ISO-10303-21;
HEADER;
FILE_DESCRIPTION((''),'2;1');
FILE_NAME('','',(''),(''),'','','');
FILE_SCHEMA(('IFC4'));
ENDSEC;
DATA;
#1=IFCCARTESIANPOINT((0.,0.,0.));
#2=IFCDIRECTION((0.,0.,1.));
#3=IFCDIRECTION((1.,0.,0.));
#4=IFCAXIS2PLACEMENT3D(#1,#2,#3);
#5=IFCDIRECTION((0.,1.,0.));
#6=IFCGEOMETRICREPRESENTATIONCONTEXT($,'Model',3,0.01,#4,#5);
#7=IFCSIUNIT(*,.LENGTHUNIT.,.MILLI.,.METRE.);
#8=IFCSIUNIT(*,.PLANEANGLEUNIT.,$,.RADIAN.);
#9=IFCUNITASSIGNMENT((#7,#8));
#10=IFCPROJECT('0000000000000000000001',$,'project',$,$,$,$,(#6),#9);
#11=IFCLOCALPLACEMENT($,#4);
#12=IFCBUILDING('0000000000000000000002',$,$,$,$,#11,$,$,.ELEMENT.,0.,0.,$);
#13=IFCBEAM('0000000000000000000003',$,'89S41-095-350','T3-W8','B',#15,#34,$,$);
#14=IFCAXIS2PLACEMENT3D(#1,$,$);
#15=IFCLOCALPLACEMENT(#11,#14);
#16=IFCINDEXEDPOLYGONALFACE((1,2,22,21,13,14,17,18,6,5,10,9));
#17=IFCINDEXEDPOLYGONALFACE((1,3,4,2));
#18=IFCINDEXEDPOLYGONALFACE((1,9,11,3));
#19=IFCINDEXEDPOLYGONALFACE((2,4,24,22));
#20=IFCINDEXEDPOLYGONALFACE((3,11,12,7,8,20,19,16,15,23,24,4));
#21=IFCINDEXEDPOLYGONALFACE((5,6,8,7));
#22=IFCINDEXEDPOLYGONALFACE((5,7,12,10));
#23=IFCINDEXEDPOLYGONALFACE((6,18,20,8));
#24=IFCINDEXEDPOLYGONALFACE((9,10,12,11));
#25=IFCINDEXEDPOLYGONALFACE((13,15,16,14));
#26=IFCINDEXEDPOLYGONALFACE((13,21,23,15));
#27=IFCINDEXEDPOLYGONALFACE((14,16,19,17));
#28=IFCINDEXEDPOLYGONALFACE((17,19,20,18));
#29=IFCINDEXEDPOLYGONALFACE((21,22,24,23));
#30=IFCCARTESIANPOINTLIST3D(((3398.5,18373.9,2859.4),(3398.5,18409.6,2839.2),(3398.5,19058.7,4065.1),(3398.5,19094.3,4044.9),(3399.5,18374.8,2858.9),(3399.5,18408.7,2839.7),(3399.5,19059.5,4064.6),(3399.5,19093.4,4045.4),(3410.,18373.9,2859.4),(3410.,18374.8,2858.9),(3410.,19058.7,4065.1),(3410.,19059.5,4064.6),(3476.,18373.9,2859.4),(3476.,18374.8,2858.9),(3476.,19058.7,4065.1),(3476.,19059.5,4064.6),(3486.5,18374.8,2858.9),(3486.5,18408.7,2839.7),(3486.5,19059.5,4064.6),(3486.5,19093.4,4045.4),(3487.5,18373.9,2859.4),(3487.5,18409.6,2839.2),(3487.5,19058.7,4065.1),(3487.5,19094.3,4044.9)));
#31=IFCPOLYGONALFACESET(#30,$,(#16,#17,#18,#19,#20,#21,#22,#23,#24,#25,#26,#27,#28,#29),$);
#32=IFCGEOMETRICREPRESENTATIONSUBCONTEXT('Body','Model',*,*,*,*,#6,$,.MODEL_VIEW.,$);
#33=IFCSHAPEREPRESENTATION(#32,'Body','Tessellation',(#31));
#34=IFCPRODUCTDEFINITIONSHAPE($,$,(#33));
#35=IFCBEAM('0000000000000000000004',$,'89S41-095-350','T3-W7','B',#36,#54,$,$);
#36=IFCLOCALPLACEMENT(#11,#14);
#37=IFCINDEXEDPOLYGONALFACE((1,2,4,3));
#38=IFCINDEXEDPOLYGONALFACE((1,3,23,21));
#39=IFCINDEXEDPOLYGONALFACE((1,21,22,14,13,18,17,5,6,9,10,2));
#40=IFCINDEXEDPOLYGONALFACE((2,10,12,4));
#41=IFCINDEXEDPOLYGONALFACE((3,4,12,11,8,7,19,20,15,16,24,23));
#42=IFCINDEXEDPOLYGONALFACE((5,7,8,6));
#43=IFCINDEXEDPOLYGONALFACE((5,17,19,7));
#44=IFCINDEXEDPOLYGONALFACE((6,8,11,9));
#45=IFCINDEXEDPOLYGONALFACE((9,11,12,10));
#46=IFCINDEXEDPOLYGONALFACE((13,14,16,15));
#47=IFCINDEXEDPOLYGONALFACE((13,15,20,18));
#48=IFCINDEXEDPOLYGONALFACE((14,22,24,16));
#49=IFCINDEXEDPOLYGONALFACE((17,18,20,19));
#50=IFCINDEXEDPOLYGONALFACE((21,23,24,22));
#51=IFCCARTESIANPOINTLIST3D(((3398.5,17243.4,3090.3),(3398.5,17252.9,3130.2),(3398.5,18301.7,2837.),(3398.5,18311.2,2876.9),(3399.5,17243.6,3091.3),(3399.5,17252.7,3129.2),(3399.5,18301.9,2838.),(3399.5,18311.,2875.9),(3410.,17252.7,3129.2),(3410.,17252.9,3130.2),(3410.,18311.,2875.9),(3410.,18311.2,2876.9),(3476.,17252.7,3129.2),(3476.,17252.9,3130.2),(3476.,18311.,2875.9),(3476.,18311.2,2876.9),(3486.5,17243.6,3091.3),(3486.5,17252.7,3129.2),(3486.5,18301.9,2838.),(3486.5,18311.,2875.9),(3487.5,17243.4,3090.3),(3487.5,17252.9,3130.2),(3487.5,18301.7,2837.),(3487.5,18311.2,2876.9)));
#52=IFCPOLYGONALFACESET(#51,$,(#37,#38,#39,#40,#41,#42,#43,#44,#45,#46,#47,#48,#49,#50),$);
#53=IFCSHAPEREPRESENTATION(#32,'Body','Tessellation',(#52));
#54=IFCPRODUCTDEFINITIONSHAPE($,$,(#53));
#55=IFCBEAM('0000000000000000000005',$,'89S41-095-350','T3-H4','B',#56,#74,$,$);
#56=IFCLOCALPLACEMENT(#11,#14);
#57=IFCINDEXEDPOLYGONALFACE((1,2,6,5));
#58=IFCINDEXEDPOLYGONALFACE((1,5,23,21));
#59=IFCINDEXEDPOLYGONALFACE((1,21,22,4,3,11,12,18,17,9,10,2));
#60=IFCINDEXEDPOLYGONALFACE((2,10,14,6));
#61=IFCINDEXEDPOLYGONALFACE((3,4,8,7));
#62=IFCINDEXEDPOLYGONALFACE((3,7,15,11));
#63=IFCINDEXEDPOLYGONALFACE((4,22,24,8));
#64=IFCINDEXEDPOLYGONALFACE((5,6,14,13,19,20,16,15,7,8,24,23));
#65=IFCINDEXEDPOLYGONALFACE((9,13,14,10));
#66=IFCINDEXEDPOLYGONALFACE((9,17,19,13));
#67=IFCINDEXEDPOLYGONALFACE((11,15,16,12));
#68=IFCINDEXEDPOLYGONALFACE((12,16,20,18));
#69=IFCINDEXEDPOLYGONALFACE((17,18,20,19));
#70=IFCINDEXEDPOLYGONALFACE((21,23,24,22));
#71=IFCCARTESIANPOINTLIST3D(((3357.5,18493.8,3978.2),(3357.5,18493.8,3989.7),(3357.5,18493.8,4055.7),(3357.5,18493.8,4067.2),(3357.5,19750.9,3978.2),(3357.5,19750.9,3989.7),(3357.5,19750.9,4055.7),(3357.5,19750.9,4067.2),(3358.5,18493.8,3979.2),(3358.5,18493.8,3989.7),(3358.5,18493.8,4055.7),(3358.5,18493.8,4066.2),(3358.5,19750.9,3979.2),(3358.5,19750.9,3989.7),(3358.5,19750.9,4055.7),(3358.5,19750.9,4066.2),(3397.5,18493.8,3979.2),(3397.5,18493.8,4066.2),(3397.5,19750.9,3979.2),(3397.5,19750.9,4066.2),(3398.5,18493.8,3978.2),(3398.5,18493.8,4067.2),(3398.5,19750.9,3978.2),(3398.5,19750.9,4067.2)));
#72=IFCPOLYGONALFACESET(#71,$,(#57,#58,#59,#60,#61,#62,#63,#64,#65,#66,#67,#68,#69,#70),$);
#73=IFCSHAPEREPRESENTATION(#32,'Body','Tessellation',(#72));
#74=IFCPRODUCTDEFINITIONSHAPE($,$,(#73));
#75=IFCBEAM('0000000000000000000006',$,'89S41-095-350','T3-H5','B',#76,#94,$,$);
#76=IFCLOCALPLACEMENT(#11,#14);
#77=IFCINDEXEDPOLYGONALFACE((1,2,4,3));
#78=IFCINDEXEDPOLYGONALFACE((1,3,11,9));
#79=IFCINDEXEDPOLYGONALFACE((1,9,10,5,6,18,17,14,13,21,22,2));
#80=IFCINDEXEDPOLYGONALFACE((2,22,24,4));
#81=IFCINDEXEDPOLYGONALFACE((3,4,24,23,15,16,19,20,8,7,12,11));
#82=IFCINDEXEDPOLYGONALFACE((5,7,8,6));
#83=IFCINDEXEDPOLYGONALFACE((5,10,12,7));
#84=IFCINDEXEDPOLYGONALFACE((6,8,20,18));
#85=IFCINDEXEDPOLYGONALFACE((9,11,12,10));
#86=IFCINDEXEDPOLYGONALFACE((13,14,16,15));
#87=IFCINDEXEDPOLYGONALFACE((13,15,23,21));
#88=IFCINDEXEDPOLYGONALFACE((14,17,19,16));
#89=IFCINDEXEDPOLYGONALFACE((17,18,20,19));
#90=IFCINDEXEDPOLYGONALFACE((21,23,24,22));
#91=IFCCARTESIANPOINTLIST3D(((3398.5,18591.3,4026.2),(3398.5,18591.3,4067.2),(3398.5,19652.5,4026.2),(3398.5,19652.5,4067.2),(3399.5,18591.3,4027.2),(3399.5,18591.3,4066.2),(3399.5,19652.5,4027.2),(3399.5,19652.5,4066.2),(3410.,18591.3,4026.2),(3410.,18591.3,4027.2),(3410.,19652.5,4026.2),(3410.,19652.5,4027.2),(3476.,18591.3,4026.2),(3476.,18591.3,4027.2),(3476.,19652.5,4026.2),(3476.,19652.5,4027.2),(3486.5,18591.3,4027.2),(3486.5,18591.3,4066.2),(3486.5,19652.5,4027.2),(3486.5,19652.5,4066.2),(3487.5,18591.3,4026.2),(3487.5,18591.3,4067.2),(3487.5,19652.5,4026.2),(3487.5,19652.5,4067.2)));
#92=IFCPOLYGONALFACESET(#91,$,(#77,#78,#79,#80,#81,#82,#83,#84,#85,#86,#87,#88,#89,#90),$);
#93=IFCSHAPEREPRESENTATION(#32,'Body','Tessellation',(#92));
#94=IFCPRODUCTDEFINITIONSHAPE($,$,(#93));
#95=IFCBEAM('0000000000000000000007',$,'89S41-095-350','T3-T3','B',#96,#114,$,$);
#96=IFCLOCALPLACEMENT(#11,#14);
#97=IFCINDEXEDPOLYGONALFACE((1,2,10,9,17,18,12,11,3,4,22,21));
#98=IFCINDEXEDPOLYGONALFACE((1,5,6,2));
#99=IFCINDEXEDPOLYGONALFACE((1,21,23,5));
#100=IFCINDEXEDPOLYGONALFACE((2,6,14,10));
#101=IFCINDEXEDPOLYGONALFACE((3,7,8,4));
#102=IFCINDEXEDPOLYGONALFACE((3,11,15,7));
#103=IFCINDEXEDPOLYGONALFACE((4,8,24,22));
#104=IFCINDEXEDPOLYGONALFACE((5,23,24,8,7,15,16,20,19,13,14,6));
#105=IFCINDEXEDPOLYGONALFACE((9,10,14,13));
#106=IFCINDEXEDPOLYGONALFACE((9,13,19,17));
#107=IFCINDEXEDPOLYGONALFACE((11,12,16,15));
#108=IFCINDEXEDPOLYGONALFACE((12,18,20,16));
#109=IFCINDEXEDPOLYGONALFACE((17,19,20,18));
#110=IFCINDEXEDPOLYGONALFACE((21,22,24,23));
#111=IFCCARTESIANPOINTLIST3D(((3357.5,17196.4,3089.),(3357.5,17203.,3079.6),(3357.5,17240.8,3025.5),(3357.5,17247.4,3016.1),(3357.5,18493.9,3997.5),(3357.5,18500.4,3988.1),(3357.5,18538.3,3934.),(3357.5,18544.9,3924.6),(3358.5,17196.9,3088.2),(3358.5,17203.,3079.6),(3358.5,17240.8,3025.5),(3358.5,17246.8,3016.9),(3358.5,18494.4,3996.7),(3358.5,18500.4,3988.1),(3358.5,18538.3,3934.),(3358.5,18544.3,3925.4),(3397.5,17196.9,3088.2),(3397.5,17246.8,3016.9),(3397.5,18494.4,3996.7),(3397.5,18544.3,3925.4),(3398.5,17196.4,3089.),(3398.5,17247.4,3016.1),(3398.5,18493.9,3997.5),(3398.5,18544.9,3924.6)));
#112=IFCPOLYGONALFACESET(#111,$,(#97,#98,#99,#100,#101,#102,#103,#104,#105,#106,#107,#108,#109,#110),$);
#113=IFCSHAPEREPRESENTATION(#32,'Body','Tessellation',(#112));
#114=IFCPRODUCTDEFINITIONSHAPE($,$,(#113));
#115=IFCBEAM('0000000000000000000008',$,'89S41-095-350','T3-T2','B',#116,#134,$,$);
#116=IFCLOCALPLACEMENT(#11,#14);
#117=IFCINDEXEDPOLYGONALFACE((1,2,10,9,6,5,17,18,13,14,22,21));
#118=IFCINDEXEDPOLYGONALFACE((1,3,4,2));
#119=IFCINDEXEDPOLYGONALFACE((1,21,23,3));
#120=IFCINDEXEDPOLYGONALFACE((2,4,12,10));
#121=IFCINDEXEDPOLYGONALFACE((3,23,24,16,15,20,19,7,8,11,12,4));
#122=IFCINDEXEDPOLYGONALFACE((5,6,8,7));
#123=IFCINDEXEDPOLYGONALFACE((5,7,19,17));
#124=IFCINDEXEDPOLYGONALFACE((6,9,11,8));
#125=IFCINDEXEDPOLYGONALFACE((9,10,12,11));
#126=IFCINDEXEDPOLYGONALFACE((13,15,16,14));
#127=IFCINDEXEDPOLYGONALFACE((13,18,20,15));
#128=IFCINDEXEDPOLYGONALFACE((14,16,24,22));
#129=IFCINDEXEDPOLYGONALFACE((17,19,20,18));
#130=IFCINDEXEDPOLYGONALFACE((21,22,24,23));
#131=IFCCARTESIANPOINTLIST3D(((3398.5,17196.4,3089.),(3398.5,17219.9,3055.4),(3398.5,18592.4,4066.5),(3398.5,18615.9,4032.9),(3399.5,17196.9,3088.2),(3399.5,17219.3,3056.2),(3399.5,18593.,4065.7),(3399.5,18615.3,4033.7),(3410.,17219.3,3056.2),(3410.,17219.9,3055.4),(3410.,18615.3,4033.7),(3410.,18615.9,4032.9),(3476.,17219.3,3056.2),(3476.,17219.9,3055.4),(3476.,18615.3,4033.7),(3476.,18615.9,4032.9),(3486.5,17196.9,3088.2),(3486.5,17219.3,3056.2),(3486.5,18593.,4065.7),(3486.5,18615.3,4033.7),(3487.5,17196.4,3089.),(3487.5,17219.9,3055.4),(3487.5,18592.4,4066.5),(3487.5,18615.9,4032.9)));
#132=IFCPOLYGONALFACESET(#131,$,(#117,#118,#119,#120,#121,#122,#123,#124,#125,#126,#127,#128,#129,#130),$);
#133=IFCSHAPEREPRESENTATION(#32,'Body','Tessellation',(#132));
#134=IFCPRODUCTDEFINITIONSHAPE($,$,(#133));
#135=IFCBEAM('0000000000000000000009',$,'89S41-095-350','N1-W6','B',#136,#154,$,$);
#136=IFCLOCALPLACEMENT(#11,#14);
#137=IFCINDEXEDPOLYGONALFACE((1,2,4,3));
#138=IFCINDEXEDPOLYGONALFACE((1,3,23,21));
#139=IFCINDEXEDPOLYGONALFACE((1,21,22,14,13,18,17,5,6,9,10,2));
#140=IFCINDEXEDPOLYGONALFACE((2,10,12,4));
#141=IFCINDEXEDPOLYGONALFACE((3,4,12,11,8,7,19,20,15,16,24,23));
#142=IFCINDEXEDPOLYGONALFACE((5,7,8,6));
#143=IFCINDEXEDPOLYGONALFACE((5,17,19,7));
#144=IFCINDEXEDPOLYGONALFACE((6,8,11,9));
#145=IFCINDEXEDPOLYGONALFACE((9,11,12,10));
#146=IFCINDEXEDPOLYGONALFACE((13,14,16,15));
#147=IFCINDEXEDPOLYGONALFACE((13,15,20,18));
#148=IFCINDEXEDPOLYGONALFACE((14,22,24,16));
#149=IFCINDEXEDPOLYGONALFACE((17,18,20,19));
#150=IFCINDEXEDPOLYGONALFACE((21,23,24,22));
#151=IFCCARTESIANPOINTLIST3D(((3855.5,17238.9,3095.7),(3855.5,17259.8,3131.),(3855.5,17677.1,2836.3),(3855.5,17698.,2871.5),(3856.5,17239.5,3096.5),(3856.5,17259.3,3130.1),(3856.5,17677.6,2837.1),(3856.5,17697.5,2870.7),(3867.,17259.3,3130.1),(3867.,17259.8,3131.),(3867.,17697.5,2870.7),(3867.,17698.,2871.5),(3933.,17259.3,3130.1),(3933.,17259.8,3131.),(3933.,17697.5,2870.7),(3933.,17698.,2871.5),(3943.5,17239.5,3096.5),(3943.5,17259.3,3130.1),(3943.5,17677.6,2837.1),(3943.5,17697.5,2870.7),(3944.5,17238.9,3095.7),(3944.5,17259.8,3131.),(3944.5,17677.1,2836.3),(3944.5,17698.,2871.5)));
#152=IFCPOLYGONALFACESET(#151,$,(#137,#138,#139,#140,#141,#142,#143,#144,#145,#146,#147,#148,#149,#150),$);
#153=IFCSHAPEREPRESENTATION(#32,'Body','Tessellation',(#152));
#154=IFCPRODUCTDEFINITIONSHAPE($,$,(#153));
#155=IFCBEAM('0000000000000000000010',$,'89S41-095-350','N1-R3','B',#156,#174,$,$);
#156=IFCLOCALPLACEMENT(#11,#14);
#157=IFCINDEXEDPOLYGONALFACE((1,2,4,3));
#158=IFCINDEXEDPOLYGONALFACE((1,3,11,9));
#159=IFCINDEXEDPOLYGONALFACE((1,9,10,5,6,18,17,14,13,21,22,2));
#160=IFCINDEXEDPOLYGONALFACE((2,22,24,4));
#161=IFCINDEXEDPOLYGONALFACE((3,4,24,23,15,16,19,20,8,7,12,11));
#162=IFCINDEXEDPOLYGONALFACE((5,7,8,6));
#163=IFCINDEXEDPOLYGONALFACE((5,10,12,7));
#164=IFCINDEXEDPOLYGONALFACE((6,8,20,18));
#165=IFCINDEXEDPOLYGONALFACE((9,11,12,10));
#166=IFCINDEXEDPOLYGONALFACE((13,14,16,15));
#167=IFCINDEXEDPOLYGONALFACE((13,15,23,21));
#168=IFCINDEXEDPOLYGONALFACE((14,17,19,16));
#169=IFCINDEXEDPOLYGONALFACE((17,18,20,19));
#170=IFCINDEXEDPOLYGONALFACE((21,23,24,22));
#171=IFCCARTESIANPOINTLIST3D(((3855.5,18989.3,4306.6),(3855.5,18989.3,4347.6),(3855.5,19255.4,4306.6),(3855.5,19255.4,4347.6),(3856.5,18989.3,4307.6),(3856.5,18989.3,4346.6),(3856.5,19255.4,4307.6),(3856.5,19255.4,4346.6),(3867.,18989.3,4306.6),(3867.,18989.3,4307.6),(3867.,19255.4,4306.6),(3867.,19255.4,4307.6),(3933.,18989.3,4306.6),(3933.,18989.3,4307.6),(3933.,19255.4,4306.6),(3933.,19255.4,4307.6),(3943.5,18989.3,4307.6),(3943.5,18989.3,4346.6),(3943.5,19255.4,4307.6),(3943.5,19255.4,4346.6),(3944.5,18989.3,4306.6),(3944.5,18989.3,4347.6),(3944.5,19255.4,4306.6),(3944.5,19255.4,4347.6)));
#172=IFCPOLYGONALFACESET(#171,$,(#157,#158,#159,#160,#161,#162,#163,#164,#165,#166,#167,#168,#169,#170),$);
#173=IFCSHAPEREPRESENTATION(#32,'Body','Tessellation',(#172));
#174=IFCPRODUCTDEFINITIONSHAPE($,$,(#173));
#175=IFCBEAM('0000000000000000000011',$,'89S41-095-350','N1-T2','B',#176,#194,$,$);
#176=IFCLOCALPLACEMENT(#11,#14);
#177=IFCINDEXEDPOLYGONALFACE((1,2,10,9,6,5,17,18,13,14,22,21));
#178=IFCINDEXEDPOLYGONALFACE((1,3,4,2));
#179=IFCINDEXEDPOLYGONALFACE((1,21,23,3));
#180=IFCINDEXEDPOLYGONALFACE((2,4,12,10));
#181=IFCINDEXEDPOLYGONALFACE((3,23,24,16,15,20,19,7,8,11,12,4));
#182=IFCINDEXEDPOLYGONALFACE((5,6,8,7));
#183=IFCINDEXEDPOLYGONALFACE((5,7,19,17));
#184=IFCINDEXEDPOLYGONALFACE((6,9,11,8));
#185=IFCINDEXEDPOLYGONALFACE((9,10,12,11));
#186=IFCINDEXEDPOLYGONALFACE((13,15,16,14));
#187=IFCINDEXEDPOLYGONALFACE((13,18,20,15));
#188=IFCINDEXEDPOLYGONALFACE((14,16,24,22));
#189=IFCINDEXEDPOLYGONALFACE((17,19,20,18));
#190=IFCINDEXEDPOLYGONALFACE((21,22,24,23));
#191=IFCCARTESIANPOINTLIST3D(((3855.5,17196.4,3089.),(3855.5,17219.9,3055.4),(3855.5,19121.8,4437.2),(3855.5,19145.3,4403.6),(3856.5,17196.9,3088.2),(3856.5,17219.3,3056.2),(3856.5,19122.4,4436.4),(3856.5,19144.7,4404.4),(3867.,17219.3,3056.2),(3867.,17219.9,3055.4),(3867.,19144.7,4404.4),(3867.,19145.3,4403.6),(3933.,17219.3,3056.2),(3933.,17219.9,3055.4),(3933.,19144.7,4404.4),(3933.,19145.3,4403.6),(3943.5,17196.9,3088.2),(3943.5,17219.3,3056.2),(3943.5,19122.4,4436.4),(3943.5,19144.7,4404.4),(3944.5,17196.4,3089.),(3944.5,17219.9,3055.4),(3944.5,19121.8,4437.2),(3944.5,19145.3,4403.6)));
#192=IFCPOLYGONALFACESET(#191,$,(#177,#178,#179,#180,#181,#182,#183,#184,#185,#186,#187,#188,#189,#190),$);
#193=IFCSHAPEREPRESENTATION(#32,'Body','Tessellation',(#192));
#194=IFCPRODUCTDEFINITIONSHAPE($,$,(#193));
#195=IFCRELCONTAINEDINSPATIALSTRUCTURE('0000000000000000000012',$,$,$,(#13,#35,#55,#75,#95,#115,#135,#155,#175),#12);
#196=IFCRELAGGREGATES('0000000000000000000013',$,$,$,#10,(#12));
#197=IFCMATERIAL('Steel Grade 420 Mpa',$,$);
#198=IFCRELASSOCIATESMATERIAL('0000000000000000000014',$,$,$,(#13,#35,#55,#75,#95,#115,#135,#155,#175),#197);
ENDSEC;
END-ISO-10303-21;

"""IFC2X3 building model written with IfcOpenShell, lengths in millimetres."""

from ifc_helpers import new_model, si_unit, direction, frame, origin, origin_with_axes, origin_2d_with_axis, place, context, subcontext, project, spatial, c_section, extrude, source, transform, mapped, material, element, save


model = new_model("IFC2X3")

# Units and contexts
model_context = context("Model", 3, precision=0.01, world=origin_with_axes(), true_north=direction((0.0, 1.0, 0.0)))
body_context = subcontext(model_context, "Body", "Model", "MODEL_VIEW")
ifc_project = project(units=[si_unit("LENGTHUNIT", "METRE", prefix="MILLI"), si_unit("PLANEANGLEUNIT", "RADIAN")], contexts=[model_context])

# Building
building_placement = place(None, origin_with_axes())
building = spatial("IfcBuilding", under=ifc_project, at=building_placement, CompositionType="ELEMENT", ElevationOfRefHeight=0.0, ElevationOfTerrain=0.0)

# Shared definitions
ifc_material = material(Name="Steel Grade 420 Mpa")

# Beams
shared_shape_1 = source(origin(), body_context, "Body", "SweptSolid", [
    extrude(c_section(Depth=89.0, Width=41.0, WallThickness=1.0, Girth=11.5, at=origin_2d_with_axis()), origin_with_axes(), (0.0, 0.0, 1.0), 1386.6),
])
beam_1_placement = place(None, frame((3443.0, 19076.5, 4055.0), z_axis=(0.0, -0.493844, -0.869551), x_axis=(0.0, -0.869551, 0.493844)))
element("IfcBeam", 1, at=beam_1_placement, inside=building, material=ifc_material, Name="89S41-095-350", Description="T3-W8", ObjectType="B", context=body_context, shape_type="MappedRepresentation", body=[
    mapped(shared_shape_1, transform((0.0, 0.0, 0.0), scale=1.0)),
])
shared_shape_2 = source(origin(), body_context, "Body", "SweptSolid", [
    extrude(c_section(Depth=89.0, Width=41.0, WallThickness=1.0, Girth=11.5, at=origin_2d_with_axis()), origin_with_axes(), (0.0, 0.0, 1.0), 1088.2),
])
beam_2_placement = place(None, frame((3443.0, 18306.5, 2856.9), z_axis=(0.0, -0.972522, 0.23281), x_axis=(0.0, 0.23281, 0.972522)))
element("IfcBeam", 2, at=beam_2_placement, inside=building, material=ifc_material, Name="89S41-095-350", Description="T3-W7", ObjectType="B", context=body_context, shape_type="MappedRepresentation", body=[
    mapped(shared_shape_2, transform((0.0, 0.0, 0.0), scale=1.0)),
])
shared_shape_3 = source(origin(), body_context, "Body", "SweptSolid", [
    extrude(c_section(Depth=89.0, Width=41.0, WallThickness=1.0, Girth=11.5, at=origin_2d_with_axis()), origin_with_axes(), (0.0, 0.0, 1.0), 1257.0),
])
beam_3_placement = place(None, frame((3378.0, 18493.8, 4022.7), z_axis=(0.0, 1.0, 0.0), x_axis=(-1.0, 0.0, 0.0)))
element("IfcBeam", 3, at=beam_3_placement, inside=building, material=ifc_material, Name="89S41-095-350", Description="T3-H4", ObjectType="B", context=body_context, shape_type="MappedRepresentation", body=[
    mapped(shared_shape_3, transform((0.0, 0.0, 0.0), scale=1.0)),
])
shared_shape_4 = source(origin(), body_context, "Body", "SweptSolid", [
    extrude(c_section(Depth=89.0, Width=41.0, WallThickness=1.0, Girth=11.5, at=origin_2d_with_axis()), origin_with_axes(), (0.0, 0.0, 1.0), 1061.3),
])
beam_4_placement = place(None, frame((3443.0, 18591.3, 4046.7), z_axis=(0.0, 1.0, 0.0), x_axis=(0.0, 0.0, -1.0)))
element("IfcBeam", 4, at=beam_4_placement, inside=building, material=ifc_material, Name="89S41-095-350", Description="T3-H5", ObjectType="B", context=body_context, shape_type="MappedRepresentation", body=[
    mapped(shared_shape_4, transform((0.0, 0.0, 0.0), scale=1.0)),
])
shared_shape_5 = source(origin(), body_context, "Body", "SweptSolid", [
    extrude(c_section(Depth=89.0, Width=41.0, WallThickness=1.0, Girth=11.5, at=origin_2d_with_axis()), origin_with_axes(), (0.0, 0.0, 1.0), 1583.9),
])
beam_5_placement = place(None, frame((3378.0, 17221.9, 3052.5), z_axis=(0.0, 0.819152, 0.573576), x_axis=(-1.0, 0.0, 0.0)))
element("IfcBeam", 5, at=beam_5_placement, inside=building, material=ifc_material, Name="89S41-095-350", Description="T3-T3", ObjectType="B", context=body_context, shape_type="MappedRepresentation", body=[
    mapped(shared_shape_5, transform((0.0, 0.0, 0.0), scale=1.0)),
])
shared_shape_6 = source(origin(), body_context, "Body", "SweptSolid", [
    extrude(c_section(Depth=89.0, Width=41.0, WallThickness=1.0, Girth=11.5, at=origin_2d_with_axis()), origin_with_axes(), (0.0, 0.0, 1.0), 1704.2),
])
beam_6_placement = place(None, frame((3443.0, 17208.1, 3072.2), z_axis=(0.0, 0.819152, 0.573576), x_axis=(0.0, 0.573576, -0.819152)))
element("IfcBeam", 6, at=beam_6_placement, inside=building, material=ifc_material, Name="89S41-095-350", Description="T3-T2", ObjectType="B", context=body_context, shape_type="MappedRepresentation", body=[
    mapped(shared_shape_6, transform((0.0, 0.0, 0.0), scale=1.0)),
])
shared_shape_7 = source(origin(), body_context, "Body", "SweptSolid", [
    extrude(c_section(Depth=89.0, Width=41.0, WallThickness=1.0, Girth=11.5, at=origin_2d_with_axis()), origin_with_axes(), (0.0, 0.0, 1.0), 509.2),
])
beam_7_placement = place(None, frame((3900.0, 17687.6, 2853.9), z_axis=(0.0, -0.860497, 0.509455), x_axis=(0.0, 0.509455, 0.860497)))
element("IfcBeam", 7, at=beam_7_placement, inside=building, material=ifc_material, Name="89S41-095-350", Description="N1-W6", ObjectType="B", context=body_context, shape_type="MappedRepresentation", body=[
    mapped(shared_shape_7, transform((0.0, 0.0, 0.0), scale=1.0)),
])
shared_shape_8 = source(origin(), body_context, "Body", "SweptSolid", [
    extrude(c_section(Depth=89.0, Width=41.0, WallThickness=1.0, Girth=11.5, at=origin_2d_with_axis()), origin_with_axes(), (0.0, 0.0, 1.0), 266.1),
])
beam_8_placement = place(None, frame((3900.0, 18989.3, 4327.1), z_axis=(0.0, 1.0, 0.0), x_axis=(0.0, 0.0, -1.0)))
element("IfcBeam", 8, at=beam_8_placement, inside=building, material=ifc_material, Name="89S41-095-350", Description="N1-R3", ObjectType="B", context=body_context, shape_type="MappedRepresentation", body=[
    mapped(shared_shape_8, transform((0.0, 0.0, 0.0), scale=1.0)),
])
shared_shape_9 = source(origin(), body_context, "Body", "SweptSolid", [
    extrude(c_section(Depth=89.0, Width=41.0, WallThickness=1.0, Girth=11.5, at=origin_2d_with_axis()), origin_with_axes(), (0.0, 0.0, 1.0), 2350.5),
])
beam_9_placement = place(None, frame((3900.0, 17208.1, 3072.2), z_axis=(0.0, 0.819152, 0.573576), x_axis=(0.0, 0.573576, -0.819152)))
element("IfcBeam", 9, at=beam_9_placement, inside=building, material=ifc_material, Name="89S41-095-350", Description="N1-T2", ObjectType="B", context=body_context, shape_type="MappedRepresentation", body=[
    mapped(shared_shape_9, transform((0.0, 0.0, 0.0), scale=1.0)),
])

save(model, "model.ifc")
